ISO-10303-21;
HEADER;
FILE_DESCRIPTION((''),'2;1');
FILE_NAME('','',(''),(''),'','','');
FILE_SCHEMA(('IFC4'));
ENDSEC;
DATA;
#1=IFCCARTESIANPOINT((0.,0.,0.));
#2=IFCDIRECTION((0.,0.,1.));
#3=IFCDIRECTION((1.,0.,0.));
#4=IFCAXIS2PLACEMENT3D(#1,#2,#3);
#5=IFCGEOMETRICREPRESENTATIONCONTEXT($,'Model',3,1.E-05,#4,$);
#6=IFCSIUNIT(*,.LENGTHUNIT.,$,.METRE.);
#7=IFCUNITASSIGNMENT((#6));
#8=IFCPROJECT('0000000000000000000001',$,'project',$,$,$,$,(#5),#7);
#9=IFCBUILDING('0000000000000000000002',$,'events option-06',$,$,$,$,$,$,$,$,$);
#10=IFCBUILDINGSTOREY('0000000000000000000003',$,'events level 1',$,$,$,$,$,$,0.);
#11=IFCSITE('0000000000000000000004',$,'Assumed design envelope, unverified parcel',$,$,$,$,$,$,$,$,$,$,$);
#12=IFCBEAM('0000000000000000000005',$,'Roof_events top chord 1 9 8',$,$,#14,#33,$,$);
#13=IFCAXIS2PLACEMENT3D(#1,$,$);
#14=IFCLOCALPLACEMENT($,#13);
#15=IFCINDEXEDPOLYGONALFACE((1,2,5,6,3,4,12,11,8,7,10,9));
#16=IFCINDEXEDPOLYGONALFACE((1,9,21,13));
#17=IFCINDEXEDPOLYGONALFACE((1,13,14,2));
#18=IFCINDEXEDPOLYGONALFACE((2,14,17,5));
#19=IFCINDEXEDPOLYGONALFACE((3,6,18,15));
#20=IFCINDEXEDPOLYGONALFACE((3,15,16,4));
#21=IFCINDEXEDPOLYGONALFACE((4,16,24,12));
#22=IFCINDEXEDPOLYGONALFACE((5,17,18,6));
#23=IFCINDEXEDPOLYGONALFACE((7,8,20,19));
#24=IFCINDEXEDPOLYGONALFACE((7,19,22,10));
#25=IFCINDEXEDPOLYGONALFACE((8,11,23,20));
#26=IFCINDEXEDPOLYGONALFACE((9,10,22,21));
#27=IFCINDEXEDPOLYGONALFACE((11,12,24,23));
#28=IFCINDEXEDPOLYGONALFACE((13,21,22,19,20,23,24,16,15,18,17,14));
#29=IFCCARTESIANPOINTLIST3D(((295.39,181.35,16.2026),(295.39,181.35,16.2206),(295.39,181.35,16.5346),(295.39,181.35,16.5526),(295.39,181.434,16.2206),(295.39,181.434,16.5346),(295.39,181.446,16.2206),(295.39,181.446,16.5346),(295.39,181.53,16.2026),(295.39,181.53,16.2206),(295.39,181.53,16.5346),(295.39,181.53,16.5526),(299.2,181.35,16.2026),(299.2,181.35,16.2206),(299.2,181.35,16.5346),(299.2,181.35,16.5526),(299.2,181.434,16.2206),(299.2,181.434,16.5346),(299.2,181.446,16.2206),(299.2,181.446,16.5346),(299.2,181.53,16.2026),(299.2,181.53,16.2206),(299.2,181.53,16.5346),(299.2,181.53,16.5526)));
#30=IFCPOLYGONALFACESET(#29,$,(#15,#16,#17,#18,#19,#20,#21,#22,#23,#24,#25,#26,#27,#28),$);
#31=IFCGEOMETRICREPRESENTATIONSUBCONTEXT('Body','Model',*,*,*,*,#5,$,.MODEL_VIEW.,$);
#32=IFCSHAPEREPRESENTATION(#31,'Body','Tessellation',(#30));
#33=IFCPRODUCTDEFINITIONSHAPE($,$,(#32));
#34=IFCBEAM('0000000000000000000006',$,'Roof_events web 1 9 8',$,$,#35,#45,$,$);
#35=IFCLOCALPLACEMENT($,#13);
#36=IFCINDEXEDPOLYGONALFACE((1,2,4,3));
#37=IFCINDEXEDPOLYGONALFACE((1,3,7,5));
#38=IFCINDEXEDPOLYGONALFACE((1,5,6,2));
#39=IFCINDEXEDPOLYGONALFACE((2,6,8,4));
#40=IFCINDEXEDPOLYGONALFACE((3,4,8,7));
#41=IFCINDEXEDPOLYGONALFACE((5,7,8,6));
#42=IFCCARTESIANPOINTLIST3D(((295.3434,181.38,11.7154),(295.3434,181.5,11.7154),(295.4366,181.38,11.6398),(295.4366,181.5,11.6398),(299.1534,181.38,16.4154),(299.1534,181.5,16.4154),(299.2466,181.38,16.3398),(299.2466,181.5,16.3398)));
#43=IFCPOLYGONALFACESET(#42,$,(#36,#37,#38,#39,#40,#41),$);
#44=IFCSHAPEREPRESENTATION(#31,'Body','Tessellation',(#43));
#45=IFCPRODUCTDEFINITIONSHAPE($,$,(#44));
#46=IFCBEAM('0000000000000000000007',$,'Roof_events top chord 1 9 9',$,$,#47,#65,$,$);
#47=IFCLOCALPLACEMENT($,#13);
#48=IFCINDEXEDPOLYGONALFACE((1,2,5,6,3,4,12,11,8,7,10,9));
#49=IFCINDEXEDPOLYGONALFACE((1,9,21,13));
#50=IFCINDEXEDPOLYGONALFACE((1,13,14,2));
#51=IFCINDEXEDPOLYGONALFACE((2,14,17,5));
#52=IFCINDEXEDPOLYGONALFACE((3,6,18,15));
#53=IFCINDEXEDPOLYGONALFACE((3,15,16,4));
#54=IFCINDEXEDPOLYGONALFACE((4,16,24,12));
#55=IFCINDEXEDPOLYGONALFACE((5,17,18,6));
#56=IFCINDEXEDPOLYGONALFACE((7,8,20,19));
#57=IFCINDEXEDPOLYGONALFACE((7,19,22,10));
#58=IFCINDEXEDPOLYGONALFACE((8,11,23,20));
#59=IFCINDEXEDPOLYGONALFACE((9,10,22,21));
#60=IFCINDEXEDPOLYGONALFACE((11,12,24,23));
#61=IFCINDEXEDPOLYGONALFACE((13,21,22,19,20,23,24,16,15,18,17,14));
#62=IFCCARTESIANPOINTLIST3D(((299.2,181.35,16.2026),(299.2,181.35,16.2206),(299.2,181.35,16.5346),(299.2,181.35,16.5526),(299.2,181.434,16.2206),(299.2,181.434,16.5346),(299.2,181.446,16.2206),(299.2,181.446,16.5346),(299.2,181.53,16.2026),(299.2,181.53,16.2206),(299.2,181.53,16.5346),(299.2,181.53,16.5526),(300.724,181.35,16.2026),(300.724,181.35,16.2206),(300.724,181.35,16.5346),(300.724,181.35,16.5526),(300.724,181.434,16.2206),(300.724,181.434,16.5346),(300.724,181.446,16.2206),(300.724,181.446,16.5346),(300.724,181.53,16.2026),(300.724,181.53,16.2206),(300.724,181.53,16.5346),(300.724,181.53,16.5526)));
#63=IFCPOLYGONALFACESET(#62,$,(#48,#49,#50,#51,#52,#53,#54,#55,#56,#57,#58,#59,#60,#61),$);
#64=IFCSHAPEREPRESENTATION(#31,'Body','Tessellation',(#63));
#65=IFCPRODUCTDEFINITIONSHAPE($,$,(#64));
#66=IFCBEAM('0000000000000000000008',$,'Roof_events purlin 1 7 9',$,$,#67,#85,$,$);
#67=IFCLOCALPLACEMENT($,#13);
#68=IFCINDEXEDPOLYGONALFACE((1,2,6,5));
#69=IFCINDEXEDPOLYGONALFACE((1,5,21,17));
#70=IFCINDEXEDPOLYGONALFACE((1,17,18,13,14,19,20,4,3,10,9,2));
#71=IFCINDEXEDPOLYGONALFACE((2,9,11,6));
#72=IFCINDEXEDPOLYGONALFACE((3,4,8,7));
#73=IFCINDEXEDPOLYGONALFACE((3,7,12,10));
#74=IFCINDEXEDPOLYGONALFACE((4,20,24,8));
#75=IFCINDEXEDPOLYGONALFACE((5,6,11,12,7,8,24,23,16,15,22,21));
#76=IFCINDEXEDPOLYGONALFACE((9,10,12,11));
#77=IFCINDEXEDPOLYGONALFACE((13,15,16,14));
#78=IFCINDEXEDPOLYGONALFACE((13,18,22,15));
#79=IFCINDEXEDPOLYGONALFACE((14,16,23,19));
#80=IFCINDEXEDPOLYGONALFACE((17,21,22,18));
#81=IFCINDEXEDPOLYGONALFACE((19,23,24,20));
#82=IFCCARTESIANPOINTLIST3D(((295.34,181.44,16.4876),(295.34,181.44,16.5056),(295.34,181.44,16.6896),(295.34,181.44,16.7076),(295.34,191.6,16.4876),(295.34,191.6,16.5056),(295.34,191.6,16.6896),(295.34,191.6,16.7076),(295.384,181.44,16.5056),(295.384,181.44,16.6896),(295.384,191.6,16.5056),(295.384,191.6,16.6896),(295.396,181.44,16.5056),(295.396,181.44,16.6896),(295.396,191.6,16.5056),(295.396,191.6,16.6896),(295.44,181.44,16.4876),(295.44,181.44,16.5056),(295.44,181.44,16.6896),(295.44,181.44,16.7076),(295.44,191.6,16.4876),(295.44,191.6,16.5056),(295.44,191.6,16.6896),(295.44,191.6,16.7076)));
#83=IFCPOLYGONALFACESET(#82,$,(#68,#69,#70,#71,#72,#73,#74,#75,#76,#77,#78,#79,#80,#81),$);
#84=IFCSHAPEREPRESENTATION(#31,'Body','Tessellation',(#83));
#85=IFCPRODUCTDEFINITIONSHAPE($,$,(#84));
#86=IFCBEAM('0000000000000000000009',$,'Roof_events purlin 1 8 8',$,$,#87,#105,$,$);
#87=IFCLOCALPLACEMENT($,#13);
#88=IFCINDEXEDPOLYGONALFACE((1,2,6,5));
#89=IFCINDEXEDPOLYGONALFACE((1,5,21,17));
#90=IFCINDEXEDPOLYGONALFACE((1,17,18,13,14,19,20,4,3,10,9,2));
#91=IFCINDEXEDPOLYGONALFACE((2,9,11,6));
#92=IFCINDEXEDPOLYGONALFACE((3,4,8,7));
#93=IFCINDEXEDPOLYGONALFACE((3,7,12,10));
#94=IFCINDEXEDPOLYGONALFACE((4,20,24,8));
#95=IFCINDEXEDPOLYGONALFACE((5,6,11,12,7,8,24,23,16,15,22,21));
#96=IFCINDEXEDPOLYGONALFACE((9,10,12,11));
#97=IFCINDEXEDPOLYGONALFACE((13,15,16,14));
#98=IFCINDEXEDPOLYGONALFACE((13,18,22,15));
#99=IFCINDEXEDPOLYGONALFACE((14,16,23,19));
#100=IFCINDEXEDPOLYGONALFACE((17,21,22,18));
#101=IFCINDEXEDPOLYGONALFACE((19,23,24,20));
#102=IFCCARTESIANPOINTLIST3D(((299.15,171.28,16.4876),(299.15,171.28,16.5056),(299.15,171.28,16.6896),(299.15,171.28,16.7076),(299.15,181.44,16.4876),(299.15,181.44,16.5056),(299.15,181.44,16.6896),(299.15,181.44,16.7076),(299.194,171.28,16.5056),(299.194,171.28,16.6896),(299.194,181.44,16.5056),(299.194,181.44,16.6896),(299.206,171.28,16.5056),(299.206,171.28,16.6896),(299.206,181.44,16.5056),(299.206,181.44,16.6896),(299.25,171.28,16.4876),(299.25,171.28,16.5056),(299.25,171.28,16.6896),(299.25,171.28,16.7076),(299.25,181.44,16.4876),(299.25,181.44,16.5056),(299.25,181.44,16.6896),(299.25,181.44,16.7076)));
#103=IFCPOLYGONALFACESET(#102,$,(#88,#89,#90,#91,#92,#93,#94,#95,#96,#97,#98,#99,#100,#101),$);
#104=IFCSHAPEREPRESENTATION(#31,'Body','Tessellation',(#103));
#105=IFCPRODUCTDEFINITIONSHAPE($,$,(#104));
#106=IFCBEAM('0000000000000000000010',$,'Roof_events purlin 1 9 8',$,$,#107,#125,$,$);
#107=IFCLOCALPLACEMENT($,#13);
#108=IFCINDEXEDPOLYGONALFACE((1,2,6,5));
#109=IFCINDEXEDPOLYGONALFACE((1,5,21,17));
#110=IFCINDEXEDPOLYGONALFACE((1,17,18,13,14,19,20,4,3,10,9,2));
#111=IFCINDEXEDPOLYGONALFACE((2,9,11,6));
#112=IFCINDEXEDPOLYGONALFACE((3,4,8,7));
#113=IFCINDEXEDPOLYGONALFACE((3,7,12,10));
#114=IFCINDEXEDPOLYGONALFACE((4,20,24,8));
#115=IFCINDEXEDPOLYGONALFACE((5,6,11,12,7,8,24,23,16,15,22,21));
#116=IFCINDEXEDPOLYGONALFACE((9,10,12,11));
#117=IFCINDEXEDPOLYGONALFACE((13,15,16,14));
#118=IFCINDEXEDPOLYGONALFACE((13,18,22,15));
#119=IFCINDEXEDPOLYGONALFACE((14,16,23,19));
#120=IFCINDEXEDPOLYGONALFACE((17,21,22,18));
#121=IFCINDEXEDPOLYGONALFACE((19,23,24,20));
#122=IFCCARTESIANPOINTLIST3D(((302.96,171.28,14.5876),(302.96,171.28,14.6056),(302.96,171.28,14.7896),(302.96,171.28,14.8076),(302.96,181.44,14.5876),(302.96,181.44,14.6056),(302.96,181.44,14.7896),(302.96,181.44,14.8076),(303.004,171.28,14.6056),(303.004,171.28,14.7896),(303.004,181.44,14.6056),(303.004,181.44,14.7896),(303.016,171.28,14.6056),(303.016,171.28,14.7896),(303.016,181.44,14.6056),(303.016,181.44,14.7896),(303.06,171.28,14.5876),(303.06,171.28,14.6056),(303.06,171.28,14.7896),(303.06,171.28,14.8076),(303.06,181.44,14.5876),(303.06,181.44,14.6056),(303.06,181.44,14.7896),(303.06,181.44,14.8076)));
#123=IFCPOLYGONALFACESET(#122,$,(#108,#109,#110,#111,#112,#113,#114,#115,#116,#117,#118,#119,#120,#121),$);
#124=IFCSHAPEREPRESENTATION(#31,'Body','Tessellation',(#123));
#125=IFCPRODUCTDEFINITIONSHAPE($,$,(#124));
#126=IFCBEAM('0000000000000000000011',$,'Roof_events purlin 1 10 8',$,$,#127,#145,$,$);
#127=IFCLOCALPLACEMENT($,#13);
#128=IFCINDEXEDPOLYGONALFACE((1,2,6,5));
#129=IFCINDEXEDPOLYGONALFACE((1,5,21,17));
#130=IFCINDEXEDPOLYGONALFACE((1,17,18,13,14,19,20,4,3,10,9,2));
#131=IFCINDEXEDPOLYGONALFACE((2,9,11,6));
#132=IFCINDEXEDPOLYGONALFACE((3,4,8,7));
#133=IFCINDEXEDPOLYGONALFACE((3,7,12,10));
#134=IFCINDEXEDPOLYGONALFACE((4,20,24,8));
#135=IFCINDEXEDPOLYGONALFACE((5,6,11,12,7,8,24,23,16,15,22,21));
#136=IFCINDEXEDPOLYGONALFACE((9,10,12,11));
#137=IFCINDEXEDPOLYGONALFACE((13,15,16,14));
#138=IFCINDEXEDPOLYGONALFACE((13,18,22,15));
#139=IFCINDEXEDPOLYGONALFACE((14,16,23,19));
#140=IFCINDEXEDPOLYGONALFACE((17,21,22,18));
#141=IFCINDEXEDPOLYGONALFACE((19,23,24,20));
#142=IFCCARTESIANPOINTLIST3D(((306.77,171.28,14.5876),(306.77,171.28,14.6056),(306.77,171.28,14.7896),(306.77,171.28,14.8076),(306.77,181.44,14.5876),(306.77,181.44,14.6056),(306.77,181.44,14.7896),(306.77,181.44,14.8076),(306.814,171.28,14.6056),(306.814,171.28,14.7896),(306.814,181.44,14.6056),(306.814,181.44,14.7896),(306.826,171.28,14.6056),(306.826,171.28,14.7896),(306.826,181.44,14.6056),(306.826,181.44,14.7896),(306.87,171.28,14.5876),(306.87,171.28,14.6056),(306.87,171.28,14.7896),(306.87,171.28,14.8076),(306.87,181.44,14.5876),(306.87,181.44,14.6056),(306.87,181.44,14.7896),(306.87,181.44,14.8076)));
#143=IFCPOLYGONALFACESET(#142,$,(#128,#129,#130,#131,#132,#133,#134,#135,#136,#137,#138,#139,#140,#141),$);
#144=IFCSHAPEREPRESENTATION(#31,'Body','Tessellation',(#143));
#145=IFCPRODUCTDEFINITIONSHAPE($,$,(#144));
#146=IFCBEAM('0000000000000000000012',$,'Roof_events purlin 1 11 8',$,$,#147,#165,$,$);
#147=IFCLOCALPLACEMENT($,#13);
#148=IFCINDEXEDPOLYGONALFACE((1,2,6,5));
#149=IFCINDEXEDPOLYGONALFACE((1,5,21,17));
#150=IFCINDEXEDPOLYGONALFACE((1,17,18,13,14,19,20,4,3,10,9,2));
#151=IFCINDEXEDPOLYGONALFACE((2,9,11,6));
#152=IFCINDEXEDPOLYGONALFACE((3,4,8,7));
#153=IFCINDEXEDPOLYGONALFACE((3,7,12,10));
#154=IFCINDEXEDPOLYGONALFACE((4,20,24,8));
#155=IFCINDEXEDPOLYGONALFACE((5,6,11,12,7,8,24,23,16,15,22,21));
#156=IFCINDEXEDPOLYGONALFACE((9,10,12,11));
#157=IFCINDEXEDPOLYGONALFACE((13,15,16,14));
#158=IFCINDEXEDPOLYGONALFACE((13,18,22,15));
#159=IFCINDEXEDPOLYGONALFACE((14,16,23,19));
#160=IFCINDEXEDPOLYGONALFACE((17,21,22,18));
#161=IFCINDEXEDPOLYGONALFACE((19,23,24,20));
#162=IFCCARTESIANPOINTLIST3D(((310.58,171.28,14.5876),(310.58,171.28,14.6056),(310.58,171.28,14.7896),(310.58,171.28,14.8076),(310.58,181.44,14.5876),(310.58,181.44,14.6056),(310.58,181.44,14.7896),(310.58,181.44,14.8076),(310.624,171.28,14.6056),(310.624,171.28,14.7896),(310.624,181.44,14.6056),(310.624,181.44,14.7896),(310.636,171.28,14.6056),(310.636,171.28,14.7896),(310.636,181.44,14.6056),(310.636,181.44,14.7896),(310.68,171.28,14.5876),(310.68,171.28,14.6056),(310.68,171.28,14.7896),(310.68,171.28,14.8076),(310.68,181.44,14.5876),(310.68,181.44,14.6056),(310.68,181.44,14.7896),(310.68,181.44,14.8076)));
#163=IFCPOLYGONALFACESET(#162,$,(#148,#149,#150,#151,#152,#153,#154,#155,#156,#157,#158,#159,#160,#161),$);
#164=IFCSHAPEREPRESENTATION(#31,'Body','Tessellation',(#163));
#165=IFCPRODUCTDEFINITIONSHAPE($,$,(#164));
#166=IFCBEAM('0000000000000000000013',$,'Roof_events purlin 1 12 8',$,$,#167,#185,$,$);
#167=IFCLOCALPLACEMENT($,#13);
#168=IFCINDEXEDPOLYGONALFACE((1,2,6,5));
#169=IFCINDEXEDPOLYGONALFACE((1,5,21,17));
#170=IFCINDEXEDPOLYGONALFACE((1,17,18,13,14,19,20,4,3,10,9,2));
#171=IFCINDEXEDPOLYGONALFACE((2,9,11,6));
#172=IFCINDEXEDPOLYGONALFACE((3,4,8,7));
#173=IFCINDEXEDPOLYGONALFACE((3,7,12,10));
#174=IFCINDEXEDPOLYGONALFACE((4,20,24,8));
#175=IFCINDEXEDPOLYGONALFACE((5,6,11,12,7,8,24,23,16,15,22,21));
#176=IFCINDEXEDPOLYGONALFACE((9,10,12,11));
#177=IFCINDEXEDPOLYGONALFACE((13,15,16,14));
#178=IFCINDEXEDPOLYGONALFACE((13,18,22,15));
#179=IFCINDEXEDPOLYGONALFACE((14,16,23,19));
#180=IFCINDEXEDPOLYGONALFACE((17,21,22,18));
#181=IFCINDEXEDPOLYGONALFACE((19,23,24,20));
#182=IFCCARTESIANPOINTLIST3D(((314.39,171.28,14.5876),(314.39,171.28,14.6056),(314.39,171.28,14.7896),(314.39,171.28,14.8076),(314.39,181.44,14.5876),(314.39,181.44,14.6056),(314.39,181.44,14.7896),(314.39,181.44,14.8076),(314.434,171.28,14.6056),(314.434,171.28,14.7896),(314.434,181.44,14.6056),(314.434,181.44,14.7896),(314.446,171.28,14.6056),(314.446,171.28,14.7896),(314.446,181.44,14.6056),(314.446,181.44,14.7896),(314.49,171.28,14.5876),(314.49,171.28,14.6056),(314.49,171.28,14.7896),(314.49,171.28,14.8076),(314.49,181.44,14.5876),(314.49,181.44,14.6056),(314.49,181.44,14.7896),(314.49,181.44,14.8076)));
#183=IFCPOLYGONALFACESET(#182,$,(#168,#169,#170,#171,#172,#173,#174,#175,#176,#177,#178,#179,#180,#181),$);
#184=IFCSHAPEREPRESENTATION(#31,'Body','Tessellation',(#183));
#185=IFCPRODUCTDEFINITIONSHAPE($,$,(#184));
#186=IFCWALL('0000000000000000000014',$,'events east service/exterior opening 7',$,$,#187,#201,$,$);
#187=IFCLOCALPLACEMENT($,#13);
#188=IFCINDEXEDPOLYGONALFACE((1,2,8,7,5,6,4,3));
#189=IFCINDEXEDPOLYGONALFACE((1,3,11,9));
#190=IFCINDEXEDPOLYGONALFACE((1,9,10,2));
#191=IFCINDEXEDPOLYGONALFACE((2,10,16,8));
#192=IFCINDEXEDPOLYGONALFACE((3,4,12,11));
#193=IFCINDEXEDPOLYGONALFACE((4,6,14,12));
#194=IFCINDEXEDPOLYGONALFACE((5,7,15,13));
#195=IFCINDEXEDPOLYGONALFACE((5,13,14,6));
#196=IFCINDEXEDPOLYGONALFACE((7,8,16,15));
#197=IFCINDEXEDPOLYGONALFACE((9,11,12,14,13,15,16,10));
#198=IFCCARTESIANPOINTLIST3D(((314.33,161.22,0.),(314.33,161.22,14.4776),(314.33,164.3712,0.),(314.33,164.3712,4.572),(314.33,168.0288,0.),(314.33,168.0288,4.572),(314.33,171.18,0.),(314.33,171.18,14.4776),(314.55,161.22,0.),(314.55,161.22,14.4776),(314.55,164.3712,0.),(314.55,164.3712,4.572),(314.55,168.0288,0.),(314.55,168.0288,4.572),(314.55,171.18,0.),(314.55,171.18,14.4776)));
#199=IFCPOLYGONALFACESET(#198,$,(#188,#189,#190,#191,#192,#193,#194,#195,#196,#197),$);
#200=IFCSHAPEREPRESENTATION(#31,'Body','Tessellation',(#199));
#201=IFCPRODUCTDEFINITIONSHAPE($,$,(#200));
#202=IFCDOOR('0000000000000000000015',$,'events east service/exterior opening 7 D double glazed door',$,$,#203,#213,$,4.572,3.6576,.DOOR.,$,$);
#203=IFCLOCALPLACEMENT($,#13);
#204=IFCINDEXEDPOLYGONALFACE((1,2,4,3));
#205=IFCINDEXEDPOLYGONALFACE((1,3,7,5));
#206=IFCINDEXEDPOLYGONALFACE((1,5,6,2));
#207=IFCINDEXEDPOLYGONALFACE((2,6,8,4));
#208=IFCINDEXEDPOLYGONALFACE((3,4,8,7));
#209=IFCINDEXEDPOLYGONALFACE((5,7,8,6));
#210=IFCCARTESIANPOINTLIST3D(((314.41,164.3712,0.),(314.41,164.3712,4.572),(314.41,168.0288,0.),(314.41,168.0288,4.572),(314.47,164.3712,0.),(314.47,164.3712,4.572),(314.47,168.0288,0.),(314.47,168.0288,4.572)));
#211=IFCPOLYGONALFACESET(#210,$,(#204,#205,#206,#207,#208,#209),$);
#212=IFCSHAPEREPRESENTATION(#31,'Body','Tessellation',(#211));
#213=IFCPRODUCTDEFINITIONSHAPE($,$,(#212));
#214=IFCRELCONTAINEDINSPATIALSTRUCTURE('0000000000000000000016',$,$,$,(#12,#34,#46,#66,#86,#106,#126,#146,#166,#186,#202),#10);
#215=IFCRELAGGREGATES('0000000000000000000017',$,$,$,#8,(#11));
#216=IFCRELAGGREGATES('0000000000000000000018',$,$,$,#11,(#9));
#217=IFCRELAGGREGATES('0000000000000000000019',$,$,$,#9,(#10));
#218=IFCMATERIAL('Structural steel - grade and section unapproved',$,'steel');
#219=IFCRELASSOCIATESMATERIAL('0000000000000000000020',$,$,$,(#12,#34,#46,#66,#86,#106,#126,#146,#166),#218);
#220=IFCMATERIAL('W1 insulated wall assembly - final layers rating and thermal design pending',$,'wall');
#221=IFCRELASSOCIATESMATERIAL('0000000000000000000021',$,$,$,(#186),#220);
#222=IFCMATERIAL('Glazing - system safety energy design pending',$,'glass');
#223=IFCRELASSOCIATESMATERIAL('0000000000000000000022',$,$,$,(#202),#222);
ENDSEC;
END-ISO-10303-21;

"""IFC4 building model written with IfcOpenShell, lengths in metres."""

from ifc_helpers import new_model, si_unit, frame, origin_with_axes, place, context, subcontext, project, spatial, rectangle, i_section, extrude, material, element, fill, save


model = new_model("IFC4")

# Units and contexts
model_context = context("Model", 3, precision=1e-05, world=origin_with_axes())
body_context = subcontext(model_context, "Body", "Model", "MODEL_VIEW")
ifc_project = project(units=[si_unit("LENGTHUNIT", "METRE")], contexts=[model_context])

# Site, building, storey
site = spatial("IfcSite", under=ifc_project, Name="Assumed design envelope, unverified parcel")
building = spatial("IfcBuilding", under=site, Name="events option-06")
storey = spatial("IfcBuildingStorey", under=building, Name="events level 1", Elevation=0.0)

# Shared definitions
ifc_material_1 = material(Name="Structural steel - grade and section unapproved", Category="steel")

# Beams
beam_1_placement = place(None, frame((295.39, 181.44, 16.3776), z_axis=(1.0, 0.0, 0.0), x_axis=(0.0, 1.0, 0.0)))
element("IfcBeam", 1, at=beam_1_placement, inside=storey, material=ifc_material_1, Name="Roof_events top chord 1 9 8", context=body_context, shape_type="SweptSolid", body=[
    extrude(i_section(OverallWidth=0.18, OverallDepth=0.35, WebThickness=0.012, FlangeThickness=0.018, FilletRadius=0.0), origin_with_axes(), (0.0, 0.0, 1.0), 3.81),
])
beam_2_placement = place(None, frame((295.39, 181.44, 11.6776), z_axis=(0.629721, 0.0, 0.776821), x_axis=(0.0, 1.0, 0.0)))
element("IfcBeam", 2, at=beam_2_placement, inside=storey, material=ifc_material_1, Name="Roof_events web 1 9 8", context=body_context, shape_type="SweptSolid", body=[
    extrude(rectangle(XDim=0.12, YDim=0.12), origin_with_axes(), (0.0, 0.0, 1.0), 6.0503),
])
beam_3_placement = place(None, frame((299.2, 181.44, 16.3776), z_axis=(1.0, 0.0, 0.0), x_axis=(0.0, 1.0, 0.0)))
element("IfcBeam", 3, at=beam_3_placement, inside=storey, material=ifc_material_1, Name="Roof_events top chord 1 9 9", context=body_context, shape_type="SweptSolid", body=[
    extrude(i_section(OverallWidth=0.18, OverallDepth=0.35, WebThickness=0.012, FlangeThickness=0.018, FilletRadius=0.0), origin_with_axes(), (0.0, 0.0, 1.0), 1.524),
])
for number, where, z_axis, x_axis, name in (
    (4, (295.39, 181.44, 16.5976), (0.0, 1.0, 0.0), (-1.0, 0.0, 0.0), "Roof_events purlin 1 7 9"),
    (5, (299.2, 171.28, 16.5976), (0.0, 1.0, 0.0), (-1.0, 0.0, 0.0), "Roof_events purlin 1 8 8"),
    (6, (303.01, 171.28, 14.6976), (0.0, 1.0, 0.0), (-1.0, 0.0, 0.0), "Roof_events purlin 1 9 8"),
    (7, (306.82, 171.28, 14.6976), (0.0, 1.0, 0.0), (-1.0, 0.0, 0.0), "Roof_events purlin 1 10 8"),
    (8, (310.63, 171.28, 14.6976), (0.0, 1.0, 0.0), (-1.0, 0.0, 0.0), "Roof_events purlin 1 11 8"),
    (9, (314.44, 171.28, 14.6976), (0.0, 1.0, 0.0), (-1.0, 0.0, 0.0), "Roof_events purlin 1 12 8"),
):
    element("IfcBeam", number, at=place(None, frame(where, z_axis=z_axis, x_axis=x_axis)), inside=storey, material=ifc_material_1, Name=name, context=body_context, shape_type="SweptSolid", body=[
        extrude(i_section(OverallWidth=0.1, OverallDepth=0.22, WebThickness=0.012, FlangeThickness=0.018, FilletRadius=0.0), origin_with_axes(), (0.0, 0.0, 1.0), 10.16),
    ])

# Wall, opening, door
ifc_material_2 = material(Name="W1 insulated wall assembly - final layers rating and thermal design pending", Category="wall")
wall_1_placement = place(None, frame((314.44, 166.2, 0.0), z_axis=(0.0, 0.0, 1.0), x_axis=(0.0, 1.0, 0.0)))
wall_1 = element("IfcWall", 10, at=wall_1_placement, inside=storey, material=ifc_material_2, Name="events east service/exterior opening 7", context=body_context, shape_type="SweptSolid", body=[
    extrude(rectangle(XDim=9.96, YDim=0.22), origin_with_axes(), (0.0, 0.0, 1.0), 14.4776),
])
opening_placement = place(None, frame((314.44, 166.2, 0.0), z_axis=(0.0, 0.0, 1.0), x_axis=(0.0, 1.0, 0.0)))
opening = element("IfcOpeningElement", 11, at=opening_placement, cuts=wall_1, context=body_context, shape_type="SweptSolid", body=[
    extrude(rectangle(XDim=3.6576, YDim=0.32), origin_with_axes(), (0.0, 0.0, 1.0), 4.572),
])
ifc_material_3 = material(Name="Glazing - system safety energy design pending", Category="glass")
door_placement = place(None, frame((314.44, 166.2, 0.0), z_axis=(0.0, 0.0, 1.0), x_axis=(0.0, 1.0, 0.0)))
door = element("IfcDoor", 12, at=door_placement, inside=storey, material=ifc_material_3, Name="events east service/exterior opening 7 D double glazed door", OverallHeight=4.572, OverallWidth=3.6576, PredefinedType="DOOR", context=body_context, shape_type="SweptSolid", body=[
    extrude(rectangle(XDim=3.6576, YDim=0.06), origin_with_axes(), (0.0, 0.0, 1.0), 4.572),
])
fill(opening, door)

save(model, "model.ifc")
